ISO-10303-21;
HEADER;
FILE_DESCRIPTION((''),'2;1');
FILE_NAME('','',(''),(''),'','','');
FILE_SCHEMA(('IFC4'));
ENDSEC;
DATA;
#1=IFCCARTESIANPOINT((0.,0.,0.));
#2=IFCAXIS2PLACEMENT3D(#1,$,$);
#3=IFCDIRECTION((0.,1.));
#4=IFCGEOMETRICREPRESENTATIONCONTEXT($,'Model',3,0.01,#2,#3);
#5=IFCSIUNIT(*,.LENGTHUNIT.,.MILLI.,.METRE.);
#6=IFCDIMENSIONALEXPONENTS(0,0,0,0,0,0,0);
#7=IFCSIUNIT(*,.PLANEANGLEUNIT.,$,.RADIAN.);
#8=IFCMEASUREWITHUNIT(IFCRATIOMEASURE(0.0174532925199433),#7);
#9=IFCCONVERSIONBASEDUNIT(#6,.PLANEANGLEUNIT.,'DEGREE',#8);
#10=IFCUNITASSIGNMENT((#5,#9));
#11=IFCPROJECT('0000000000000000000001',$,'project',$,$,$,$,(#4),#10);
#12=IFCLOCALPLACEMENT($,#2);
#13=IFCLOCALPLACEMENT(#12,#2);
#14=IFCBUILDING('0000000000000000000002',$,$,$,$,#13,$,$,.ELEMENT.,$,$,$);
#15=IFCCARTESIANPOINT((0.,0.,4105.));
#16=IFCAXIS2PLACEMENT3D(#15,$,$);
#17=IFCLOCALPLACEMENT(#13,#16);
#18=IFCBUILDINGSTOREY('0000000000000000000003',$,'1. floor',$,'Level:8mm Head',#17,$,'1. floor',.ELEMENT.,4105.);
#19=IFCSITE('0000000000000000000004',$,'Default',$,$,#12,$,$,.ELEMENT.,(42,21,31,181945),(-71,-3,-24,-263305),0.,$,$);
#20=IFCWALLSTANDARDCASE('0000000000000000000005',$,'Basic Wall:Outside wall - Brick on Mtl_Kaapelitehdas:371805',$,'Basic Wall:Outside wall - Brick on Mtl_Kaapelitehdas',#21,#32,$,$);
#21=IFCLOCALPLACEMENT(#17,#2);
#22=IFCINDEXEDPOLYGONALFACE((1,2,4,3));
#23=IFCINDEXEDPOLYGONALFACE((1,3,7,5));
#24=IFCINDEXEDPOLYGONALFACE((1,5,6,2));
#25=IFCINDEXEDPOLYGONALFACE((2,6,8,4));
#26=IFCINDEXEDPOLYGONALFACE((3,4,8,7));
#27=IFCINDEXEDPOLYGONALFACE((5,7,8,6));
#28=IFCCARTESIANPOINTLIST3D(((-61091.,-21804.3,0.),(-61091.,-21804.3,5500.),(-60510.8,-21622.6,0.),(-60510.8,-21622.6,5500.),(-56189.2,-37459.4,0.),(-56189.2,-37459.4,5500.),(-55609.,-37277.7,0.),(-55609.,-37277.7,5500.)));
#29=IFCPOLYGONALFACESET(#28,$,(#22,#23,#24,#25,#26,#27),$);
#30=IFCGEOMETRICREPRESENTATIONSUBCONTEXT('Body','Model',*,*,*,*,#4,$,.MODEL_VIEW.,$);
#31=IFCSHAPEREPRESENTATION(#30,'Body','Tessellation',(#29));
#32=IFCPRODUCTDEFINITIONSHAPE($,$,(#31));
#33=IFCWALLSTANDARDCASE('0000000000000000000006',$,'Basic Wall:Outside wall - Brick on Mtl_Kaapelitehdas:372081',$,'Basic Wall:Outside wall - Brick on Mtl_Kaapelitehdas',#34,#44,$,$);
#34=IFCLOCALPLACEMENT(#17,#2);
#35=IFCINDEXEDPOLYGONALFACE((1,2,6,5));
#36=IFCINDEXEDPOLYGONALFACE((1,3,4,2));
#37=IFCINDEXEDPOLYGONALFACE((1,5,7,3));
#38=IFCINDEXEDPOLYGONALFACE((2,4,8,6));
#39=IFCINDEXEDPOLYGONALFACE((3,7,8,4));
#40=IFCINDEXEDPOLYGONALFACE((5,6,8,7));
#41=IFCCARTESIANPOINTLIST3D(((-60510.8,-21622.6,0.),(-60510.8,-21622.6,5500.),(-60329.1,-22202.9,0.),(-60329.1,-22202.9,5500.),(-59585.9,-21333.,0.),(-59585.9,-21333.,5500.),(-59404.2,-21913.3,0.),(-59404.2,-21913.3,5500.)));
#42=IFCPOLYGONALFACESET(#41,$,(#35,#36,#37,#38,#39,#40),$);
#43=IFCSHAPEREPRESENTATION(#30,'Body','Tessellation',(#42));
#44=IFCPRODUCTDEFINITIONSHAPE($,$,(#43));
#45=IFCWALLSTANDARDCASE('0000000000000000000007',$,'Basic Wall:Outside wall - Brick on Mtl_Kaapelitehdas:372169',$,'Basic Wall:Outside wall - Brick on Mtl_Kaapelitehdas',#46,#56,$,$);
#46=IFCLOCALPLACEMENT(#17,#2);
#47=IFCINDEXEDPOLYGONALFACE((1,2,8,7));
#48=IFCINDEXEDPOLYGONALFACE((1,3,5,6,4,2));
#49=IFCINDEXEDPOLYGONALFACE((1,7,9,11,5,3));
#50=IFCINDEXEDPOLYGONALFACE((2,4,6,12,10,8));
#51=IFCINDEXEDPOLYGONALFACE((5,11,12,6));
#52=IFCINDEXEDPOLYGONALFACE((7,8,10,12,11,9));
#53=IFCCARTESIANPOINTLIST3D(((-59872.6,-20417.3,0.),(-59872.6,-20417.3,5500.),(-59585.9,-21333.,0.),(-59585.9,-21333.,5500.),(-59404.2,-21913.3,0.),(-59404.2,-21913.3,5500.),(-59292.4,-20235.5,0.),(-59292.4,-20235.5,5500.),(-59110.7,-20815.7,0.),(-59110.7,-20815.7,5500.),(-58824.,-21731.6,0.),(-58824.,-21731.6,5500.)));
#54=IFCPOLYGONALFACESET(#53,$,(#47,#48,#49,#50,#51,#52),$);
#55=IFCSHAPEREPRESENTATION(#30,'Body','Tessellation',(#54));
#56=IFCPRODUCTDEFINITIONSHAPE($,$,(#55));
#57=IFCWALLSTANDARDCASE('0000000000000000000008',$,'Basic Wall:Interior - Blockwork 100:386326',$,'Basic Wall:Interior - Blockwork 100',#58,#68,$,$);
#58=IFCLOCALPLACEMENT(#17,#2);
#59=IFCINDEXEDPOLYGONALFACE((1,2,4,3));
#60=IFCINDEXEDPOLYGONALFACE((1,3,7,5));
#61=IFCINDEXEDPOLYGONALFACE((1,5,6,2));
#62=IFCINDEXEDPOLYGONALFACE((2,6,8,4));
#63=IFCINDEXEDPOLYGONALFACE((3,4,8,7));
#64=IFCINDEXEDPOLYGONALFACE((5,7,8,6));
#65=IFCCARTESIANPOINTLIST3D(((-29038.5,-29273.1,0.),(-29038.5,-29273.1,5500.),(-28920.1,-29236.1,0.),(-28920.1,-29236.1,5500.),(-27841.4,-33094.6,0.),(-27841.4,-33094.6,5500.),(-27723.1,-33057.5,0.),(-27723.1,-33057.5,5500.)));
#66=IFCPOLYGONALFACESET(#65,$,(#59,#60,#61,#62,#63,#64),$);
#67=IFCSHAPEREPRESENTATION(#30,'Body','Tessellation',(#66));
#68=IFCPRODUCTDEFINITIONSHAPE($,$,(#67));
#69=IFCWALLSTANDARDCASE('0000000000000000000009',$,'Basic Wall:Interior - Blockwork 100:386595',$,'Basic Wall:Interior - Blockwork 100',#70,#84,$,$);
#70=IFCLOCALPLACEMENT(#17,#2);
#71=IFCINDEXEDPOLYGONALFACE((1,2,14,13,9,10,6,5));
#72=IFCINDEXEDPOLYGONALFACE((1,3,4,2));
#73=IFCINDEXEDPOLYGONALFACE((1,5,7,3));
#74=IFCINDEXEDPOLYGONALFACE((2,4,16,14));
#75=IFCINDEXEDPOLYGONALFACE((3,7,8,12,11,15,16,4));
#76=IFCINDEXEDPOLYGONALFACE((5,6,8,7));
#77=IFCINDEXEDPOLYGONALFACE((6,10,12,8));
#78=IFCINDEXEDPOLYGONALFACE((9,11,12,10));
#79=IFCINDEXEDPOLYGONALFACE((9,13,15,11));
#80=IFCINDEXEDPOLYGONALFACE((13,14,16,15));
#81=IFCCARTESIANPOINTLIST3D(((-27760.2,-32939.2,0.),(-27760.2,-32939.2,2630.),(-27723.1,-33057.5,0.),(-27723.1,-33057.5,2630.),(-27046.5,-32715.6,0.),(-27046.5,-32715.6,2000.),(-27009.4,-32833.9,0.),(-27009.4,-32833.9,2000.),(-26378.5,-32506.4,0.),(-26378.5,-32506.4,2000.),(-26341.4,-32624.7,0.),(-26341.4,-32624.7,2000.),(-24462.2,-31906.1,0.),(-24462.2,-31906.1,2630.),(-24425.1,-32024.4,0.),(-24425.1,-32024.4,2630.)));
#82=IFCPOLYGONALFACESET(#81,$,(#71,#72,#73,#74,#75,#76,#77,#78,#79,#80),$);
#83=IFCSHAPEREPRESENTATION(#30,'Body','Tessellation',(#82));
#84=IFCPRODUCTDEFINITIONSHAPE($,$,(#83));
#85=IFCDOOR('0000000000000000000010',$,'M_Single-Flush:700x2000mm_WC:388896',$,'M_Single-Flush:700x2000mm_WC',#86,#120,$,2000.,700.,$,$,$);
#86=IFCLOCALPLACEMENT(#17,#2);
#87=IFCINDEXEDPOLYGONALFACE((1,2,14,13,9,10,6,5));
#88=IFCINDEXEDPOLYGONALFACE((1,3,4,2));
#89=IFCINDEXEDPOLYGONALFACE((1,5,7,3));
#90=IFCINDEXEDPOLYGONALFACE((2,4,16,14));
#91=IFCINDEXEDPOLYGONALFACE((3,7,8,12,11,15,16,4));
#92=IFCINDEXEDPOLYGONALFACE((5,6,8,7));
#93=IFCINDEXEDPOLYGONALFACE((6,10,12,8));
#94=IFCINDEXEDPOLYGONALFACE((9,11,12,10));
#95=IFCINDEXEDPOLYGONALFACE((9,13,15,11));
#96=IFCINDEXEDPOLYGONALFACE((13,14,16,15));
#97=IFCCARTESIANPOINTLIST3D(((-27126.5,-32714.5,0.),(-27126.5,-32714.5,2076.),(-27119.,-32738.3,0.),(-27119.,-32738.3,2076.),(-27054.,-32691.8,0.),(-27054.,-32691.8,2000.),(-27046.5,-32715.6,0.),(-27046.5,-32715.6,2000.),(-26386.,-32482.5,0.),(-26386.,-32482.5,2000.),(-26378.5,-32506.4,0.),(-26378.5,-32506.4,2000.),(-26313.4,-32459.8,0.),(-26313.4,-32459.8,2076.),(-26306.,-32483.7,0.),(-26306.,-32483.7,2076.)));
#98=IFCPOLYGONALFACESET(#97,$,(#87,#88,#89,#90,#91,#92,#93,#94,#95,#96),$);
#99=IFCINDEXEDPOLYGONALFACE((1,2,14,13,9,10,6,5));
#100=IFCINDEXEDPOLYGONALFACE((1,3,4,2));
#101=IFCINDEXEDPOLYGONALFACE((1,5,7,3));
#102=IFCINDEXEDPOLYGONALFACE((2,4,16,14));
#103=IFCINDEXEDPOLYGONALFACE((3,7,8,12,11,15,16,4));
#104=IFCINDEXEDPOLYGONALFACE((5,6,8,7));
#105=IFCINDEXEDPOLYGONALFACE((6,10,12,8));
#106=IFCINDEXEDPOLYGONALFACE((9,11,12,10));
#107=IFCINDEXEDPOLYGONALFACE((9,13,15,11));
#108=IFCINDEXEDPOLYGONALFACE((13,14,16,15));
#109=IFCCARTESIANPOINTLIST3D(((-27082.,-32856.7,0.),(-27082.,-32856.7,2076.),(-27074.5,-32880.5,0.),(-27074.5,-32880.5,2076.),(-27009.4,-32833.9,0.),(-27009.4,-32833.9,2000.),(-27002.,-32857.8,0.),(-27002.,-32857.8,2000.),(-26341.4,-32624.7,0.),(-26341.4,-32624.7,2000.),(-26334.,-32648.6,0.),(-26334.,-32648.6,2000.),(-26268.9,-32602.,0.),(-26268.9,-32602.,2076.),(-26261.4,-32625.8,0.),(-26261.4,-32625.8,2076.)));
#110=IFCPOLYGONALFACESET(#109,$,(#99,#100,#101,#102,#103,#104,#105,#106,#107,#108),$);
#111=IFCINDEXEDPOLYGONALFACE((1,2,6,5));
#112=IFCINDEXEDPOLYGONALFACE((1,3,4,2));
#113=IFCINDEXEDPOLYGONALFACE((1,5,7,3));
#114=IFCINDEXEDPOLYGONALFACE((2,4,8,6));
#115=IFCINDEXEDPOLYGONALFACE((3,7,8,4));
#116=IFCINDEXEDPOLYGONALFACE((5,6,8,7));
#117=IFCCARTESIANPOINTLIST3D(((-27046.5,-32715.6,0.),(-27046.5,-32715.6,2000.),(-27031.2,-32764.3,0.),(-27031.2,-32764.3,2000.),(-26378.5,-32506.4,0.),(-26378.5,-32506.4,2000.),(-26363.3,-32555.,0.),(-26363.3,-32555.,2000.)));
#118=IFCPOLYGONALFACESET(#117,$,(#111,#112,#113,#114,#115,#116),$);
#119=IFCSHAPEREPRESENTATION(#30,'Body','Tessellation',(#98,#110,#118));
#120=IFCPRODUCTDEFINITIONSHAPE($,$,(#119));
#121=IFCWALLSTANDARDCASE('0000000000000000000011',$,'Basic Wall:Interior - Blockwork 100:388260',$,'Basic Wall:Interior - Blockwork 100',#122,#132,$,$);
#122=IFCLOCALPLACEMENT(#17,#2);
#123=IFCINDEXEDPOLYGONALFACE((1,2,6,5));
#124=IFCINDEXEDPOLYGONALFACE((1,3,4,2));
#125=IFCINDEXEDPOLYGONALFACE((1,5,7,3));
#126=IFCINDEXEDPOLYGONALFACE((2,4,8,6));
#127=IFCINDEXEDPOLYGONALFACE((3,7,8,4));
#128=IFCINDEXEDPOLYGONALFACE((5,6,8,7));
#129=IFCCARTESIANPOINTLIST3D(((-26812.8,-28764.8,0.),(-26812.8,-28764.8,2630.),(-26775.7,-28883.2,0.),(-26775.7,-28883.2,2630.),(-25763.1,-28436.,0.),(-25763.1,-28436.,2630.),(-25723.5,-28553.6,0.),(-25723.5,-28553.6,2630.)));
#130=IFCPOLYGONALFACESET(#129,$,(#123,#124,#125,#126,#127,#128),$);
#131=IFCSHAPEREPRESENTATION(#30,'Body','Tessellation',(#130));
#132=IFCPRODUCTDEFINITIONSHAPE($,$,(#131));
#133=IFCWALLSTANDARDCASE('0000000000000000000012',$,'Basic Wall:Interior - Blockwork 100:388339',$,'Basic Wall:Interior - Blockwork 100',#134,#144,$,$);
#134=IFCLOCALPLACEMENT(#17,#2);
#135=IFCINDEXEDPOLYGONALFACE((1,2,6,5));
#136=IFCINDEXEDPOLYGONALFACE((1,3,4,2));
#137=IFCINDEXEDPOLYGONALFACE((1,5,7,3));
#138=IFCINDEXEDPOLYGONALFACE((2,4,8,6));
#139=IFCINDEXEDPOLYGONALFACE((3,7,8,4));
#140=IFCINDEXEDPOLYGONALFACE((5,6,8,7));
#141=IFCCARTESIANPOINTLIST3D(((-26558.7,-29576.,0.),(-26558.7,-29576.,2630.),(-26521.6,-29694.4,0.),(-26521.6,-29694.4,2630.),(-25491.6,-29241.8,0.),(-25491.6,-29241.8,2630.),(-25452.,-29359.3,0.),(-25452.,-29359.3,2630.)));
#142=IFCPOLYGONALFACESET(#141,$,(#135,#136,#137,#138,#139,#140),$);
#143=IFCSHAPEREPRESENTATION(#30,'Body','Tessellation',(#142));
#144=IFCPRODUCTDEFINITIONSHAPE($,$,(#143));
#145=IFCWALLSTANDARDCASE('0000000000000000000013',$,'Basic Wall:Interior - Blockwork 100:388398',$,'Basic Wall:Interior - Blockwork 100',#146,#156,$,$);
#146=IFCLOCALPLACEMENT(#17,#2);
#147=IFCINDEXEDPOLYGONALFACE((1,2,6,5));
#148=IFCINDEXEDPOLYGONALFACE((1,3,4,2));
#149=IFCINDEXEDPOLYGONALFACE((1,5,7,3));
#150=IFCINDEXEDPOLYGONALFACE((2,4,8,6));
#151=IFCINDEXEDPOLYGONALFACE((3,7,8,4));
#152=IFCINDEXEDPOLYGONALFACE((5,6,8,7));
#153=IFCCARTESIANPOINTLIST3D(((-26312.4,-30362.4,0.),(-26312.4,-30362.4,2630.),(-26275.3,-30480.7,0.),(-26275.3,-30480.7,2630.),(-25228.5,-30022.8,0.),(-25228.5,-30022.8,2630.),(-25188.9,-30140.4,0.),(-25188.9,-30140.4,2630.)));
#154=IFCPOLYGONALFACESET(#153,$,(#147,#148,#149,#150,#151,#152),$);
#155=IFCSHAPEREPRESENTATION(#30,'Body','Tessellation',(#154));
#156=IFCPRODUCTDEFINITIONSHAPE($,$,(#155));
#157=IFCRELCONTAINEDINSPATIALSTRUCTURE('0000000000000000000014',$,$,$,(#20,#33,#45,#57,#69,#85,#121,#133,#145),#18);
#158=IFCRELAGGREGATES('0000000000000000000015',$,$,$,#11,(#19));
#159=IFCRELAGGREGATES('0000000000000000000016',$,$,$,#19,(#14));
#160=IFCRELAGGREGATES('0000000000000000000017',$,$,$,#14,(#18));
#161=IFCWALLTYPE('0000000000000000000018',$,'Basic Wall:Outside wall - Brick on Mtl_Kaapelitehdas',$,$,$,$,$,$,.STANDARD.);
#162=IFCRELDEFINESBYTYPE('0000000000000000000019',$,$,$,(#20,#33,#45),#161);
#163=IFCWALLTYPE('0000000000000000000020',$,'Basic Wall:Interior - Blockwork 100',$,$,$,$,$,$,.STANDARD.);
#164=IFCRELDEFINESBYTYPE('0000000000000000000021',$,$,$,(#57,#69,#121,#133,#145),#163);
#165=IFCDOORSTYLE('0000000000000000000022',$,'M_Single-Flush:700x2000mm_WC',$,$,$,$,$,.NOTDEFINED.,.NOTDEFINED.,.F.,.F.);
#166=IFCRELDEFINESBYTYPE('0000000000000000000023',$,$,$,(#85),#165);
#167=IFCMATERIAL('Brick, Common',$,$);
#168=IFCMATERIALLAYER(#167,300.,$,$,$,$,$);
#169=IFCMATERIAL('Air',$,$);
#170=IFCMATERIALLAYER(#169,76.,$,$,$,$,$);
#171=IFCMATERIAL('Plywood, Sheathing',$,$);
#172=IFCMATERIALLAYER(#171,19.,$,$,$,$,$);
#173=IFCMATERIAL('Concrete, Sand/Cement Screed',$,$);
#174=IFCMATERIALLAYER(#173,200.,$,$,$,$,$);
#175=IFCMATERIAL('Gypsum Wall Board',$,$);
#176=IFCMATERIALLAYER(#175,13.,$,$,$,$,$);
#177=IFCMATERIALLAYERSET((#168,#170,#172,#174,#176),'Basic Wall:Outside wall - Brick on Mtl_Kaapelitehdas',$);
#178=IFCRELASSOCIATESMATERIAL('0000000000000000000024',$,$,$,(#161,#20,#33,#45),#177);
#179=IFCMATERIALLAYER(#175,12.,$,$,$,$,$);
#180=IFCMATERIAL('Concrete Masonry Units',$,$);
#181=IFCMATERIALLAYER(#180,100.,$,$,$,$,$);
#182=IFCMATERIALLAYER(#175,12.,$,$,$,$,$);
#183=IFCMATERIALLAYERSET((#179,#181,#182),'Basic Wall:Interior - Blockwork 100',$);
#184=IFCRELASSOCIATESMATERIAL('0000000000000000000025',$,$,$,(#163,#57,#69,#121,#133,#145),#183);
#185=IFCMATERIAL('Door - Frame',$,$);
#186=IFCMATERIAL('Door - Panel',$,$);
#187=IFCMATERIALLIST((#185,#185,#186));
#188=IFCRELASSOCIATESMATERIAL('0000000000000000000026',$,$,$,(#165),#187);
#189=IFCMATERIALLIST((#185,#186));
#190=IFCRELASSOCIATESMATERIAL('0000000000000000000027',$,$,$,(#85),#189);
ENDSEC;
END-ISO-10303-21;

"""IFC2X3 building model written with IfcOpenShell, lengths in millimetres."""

from ifc_helpers import new_model, entity, si_unit, converted_unit, direction, frame, frame_2d, origin, origin_2d_with_axis, place, context, subcontext, project, spatial, polyline, rectangle, outline, extrude, source, transform, mapped, material, material_list, layer, layer_set, layer_usage, type_object, type_shapes, element, fill, save


model = new_model("IFC2X3")

# Units and contexts
model_context = context("Model", 3, precision=0.01, world=origin(), true_north=direction((0.0, 1.0)))
body_context = subcontext(model_context, "Body", "Model", "MODEL_VIEW")
ifc_project = project(units=[si_unit("LENGTHUNIT", "METRE", prefix="MILLI"), converted_unit("PLANEANGLEUNIT", "DEGREE", entity("IfcRatioMeasure", 0.0174532925199433), si_unit("PLANEANGLEUNIT", "RADIAN"), dimensions=[0, 0, 0, 0, 0, 0, 0])], contexts=[model_context])

# Site, building, storey
site_placement = place(None, origin())
site = spatial("IfcSite", under=ifc_project, at=site_placement, Name="Default", CompositionType="ELEMENT", RefLatitude=(42, 21, 31, 181945), RefLongitude=(-71, -3, -24, -263305), RefElevation=0.0)
building_placement = place(site_placement, origin())
building = spatial("IfcBuilding", under=site, at=building_placement, CompositionType="ELEMENT")
storey_placement = place(building_placement, frame((0.0, 0.0, 4105.0)))
storey = spatial("IfcBuildingStorey", under=building, at=storey_placement, Name="1. floor", ObjectType="Level:8mm Head", LongName="1. floor", CompositionType="ELEMENT", Elevation=4105.0)

# Walls
ifc_material_1 = material(Name="Brick, Common")
ifc_layer_1 = layer(ifc_material_1, 300.0)
ifc_material_2 = material(Name="Air")
ifc_layer_2 = layer(ifc_material_2, 76.0)
ifc_material_3 = material(Name="Plywood, Sheathing")
ifc_layer_3 = layer(ifc_material_3, 19.0)
ifc_material_4 = material(Name="Concrete, Sand/Cement Screed")
ifc_layer_4 = layer(ifc_material_4, 200.0)
ifc_material_5 = material(Name="Gypsum Wall Board")
ifc_layer_5 = layer(ifc_material_5, 13.0)
ifc_layer_set_1 = layer_set([ifc_layer_1, ifc_layer_2, ifc_layer_3, ifc_layer_4, ifc_layer_5], Name="Basic Wall:Outside wall - Brick on Mtl_Kaapelitehdas")
ifc_layer_usage_1 = layer_usage(ifc_layer_set_1, "AXIS2", "NEGATIVE", 304.0)
wall_type_1 = type_object("IfcWallType", Name="Basic Wall:Outside wall - Brick on Mtl_Kaapelitehdas", PredefinedType="STANDARD", material=ifc_layer_set_1)
wall_1_placement = place(storey_placement, frame((-60800.9, -21713.5, 0.0), z_axis=(0.0, 0.0, 1.0), x_axis=(0.298805, -0.954314, 0.0)))
element("IfcWallStandardCase", 1, at=wall_1_placement, inside=storey, type_object=wall_type_1, material=ifc_layer_usage_1, Name="Basic Wall:Outside wall - Brick on Mtl_Kaapelitehdas:371805", ObjectType="Basic Wall:Outside wall - Brick on Mtl_Kaapelitehdas", context=body_context, shape_type="SweptSolid", body=[
    extrude(rectangle(XDim=16404.5, YDim=608.0, at=frame_2d((8202.3, 0.0), x_axis=(-1.0, 0.0))), origin(), (0.0, 0.0, 1.0), 5500.0),
])
ifc_layer_usage_2 = layer_usage(ifc_layer_set_1, "AXIS2", "NEGATIVE", 304.0)
wall_2_placement = place(storey_placement, frame((-60419.9, -21912.8, 0.0), z_axis=(0.0, 0.0, 1.0), x_axis=(0.954314, 0.298805, 0.0)))
element("IfcWallStandardCase", 2, at=wall_2_placement, inside=storey, type_object=wall_type_1, material=ifc_layer_usage_2, Name="Basic Wall:Outside wall - Brick on Mtl_Kaapelitehdas:372081", ObjectType="Basic Wall:Outside wall - Brick on Mtl_Kaapelitehdas", context=body_context, shape_type="SweptSolid", body=[
    extrude(rectangle(XDim=969.2, YDim=608.0, at=frame_2d((484.6, 0.0), x_axis=(-1.0, 0.0))), origin(), (0.0, 0.0, 1.0), 5500.0),
])
ifc_layer_usage_3 = layer_usage(ifc_layer_set_1, "AXIS2", "NEGATIVE", 304.0)
wall_3_placement = place(storey_placement, frame((-59114.1, -21822.4, 0.0), z_axis=(0.0, 0.0, 1.0), x_axis=(-0.298805, 0.954314, 0.0)))
element("IfcWallStandardCase", 3, at=wall_3_placement, inside=storey, type_object=wall_type_1, material=ifc_layer_usage_3, Name="Basic Wall:Outside wall - Brick on Mtl_Kaapelitehdas:372169", ObjectType="Basic Wall:Outside wall - Brick on Mtl_Kaapelitehdas", context=body_context, shape_type="SweptSolid", body=[
    extrude(outline(polyline([(1567.7, -304.0), (1567.6, 304.0), (608.0, 304.0), (0.0, 304.0), (0.0, -304.0), (959.7, -304.0), (1567.7, -304.0)])), origin(), (0.0, 0.0, 1.0), 5500.0),
])

# Wall
ifc_layer_6 = layer(ifc_material_5, 12.0)
ifc_material_6 = material(Name="Concrete Masonry Units")
ifc_layer_7 = layer(ifc_material_6, 100.0)
ifc_layer_8 = layer(ifc_material_5, 12.0)
ifc_layer_set_2 = layer_set([ifc_layer_6, ifc_layer_7, ifc_layer_8], Name="Basic Wall:Interior - Blockwork 100")
ifc_layer_usage_4 = layer_usage(ifc_layer_set_2, "AXIS2", "NEGATIVE", 62.0)
wall_type_2 = type_object("IfcWallType", Name="Basic Wall:Interior - Blockwork 100", PredefinedType="STANDARD", material=ifc_layer_set_2)
wall_4_placement = place(storey_placement, frame((-28979.3, -29254.6, 0.0), z_axis=(0.0, 0.0, 1.0), x_axis=(0.298924, -0.954277, 0.0)))
element("IfcWallStandardCase", 4, at=wall_4_placement, inside=storey, type_object=wall_type_2, material=ifc_layer_usage_4, Name="Basic Wall:Interior - Blockwork 100:386326", ObjectType="Basic Wall:Interior - Blockwork 100", context=body_context, shape_type="SweptSolid", body=[
    extrude(rectangle(XDim=4004.5, YDim=124.0, at=frame_2d((2002.3, 0.0), x_axis=(-1.0, 0.0))), origin(), (0.0, 0.0, 1.0), 5500.0),
])

# Wall, opening, door
ifc_layer_usage_5 = layer_usage(ifc_layer_set_2, "AXIS2", "NEGATIVE", 62.0)
wall_5_placement = place(storey_placement, frame((-27741.6, -32998.3, 0.0), z_axis=(0.0, 0.0, 1.0), x_axis=(0.954277, 0.298924, 0.0)))
wall_5 = element("IfcWallStandardCase", 5, at=wall_5_placement, inside=storey, type_object=wall_type_2, material=ifc_layer_usage_5, Name="Basic Wall:Interior - Blockwork 100:386595", ObjectType="Basic Wall:Interior - Blockwork 100", context=body_context, shape_type="SweptSolid", body=[
    extrude(rectangle(XDim=3456.0, YDim=124.0, at=frame_2d((1728.0, 0.0), x_axis=(-1.0, 0.0))), origin(), (0.0, 0.0, 1.0), 2630.0),
])
opening_1_placement = place(wall_5_placement, frame((747.9, -62.0, 0.0)))
opening_1 = element("IfcOpeningElement", 6, at=opening_1_placement, cuts=wall_5, ObjectType="Opening", context=body_context, shape_type="SweptSolid", body=[
    extrude(rectangle(XDim=700.0, YDim=2000.0, at=frame_2d((1000.0, 350.0), x_axis=(0.0, 1.0))), frame((0.0, 0.0, 0.0), z_axis=(0.0, 1.0, 0.0), x_axis=(0.0, 0.0, 1.0)), (0.0, 0.0, 1.0), 124.0),
])
ifc_material_7 = material(Name="Door - Frame")
ifc_material_8 = material(Name="Door - Panel")
ifc_material_list_1 = material_list([ifc_material_7, ifc_material_8])
ifc_material_list_2 = material_list([ifc_material_7, ifc_material_7, ifc_material_8])
door_style_1 = type_object("IfcDoorStyle", Name="M_Single-Flush:700x2000mm_WC", ConstructionType="NOTDEFINED", OperationType="NOTDEFINED", ParameterTakesPrecedence=False, Sizeable=False, material=ifc_material_list_2)
shared_shape_1 = source(origin(), body_context, "Body", "SweptSolid", [
    extrude(outline(polyline([(-426.0, -1057.0), (426.0, -1057.0), (426.0, 1019.0), (350.0, 1019.0), (350.0, -981.0), (-350.0, -981.0), (-350.0, 1019.0), (-426.0, 1019.0), (-426.0, -1057.0)])), frame((350.0, 124.0, 1019.0), z_axis=(0.0, 1.0, 0.0), x_axis=(1.0, 0.0, 0.0)), (0.0, 0.0, 1.0), 25.0),
    extrude(outline(polyline([(-1057.0, -426.0), (1019.0, -426.0), (1019.0, -350.0), (-981.0, -350.0), (-981.0, 350.0), (1019.0, 350.0), (1019.0, 426.0), (-1057.0, 426.0), (-1057.0, -426.0)])), frame((350.0, -25.0, 1019.0), z_axis=(0.0, 1.0, 0.0), x_axis=(0.0, 0.0, -1.0)), (0.0, 0.0, 1.0), 25.0),
    extrude(rectangle(XDim=51.0, YDim=700.0, at=origin_2d_with_axis()), frame((350.0, 98.5, 0.0), z_axis=(0.0, 0.0, 1.0), x_axis=(0.0, 1.0, 0.0)), (0.0, 0.0, 1.0), 2000.0),
])
type_shapes(door_style_1, [shared_shape_1])
door_1_placement = place(opening_1_placement, origin())
door_1 = element("IfcDoor", 7, at=door_1_placement, inside=storey, type_object=door_style_1, material=ifc_material_list_1, Name="M_Single-Flush:700x2000mm_WC:388896", ObjectType="M_Single-Flush:700x2000mm_WC", OverallHeight=2000.0, OverallWidth=700.0, context=body_context, shape_type="MappedRepresentation", body=[
    mapped(shared_shape_1, transform((0.0, 0.0, 0.0), scale=1.0)),
])
fill(opening_1, door_1)

# Walls
ifc_layer_usage_6 = layer_usage(ifc_layer_set_2, "AXIS2", "NEGATIVE", 62.0)
wall_6_placement = place(storey_placement, frame((-26794.3, -28824.0, 0.0), z_axis=(0.0, 0.0, 1.0), x_axis=(0.954277, 0.298924, 0.0)))
element("IfcWallStandardCase", 8, at=wall_6_placement, inside=storey, type_object=wall_type_2, material=ifc_layer_usage_6, Name="Basic Wall:Interior - Blockwork 100:388260", ObjectType="Basic Wall:Interior - Blockwork 100", context=body_context, shape_type="SweptSolid", body=[
    extrude(outline(polyline([(1102.6, -62.0), (1100.0, 62.0), (0.0, 62.0), (0.0, -62.0), (1102.6, -62.0)])), origin(), (0.0, 0.0, 1.0), 2630.0),
])
ifc_layer_usage_7 = layer_usage(ifc_layer_set_2, "AXIS2", "NEGATIVE", 62.0)
wall_7_placement = place(storey_placement, frame((-26540.1, -29635.2, 0.0), z_axis=(0.0, 0.0, 1.0), x_axis=(0.954277, 0.298924, 0.0)))
element("IfcWallStandardCase", 9, at=wall_7_placement, inside=storey, type_object=wall_type_2, material=ifc_layer_usage_7, Name="Basic Wall:Interior - Blockwork 100:388339", ObjectType="Basic Wall:Interior - Blockwork 100", context=body_context, shape_type="SweptSolid", body=[
    extrude(outline(polyline([(1120.8, -62.0), (1118.2, 62.0), (0.0, 62.0), (0.0, -62.0), (1120.8, -62.0)])), origin(), (0.0, 0.0, 1.0), 2630.0),
])
ifc_layer_usage_8 = layer_usage(ifc_layer_set_2, "AXIS2", "NEGATIVE", 62.0)
wall_8_placement = place(storey_placement, frame((-26293.8, -30421.5, 0.0), z_axis=(0.0, 0.0, 1.0), x_axis=(0.954277, 0.298924, 0.0)))
element("IfcWallStandardCase", 10, at=wall_8_placement, inside=storey, type_object=wall_type_2, material=ifc_layer_usage_8, Name="Basic Wall:Interior - Blockwork 100:388398", ObjectType="Basic Wall:Interior - Blockwork 100", context=body_context, shape_type="SweptSolid", body=[
    extrude(outline(polyline([(1138.5, -62.0), (1135.8, 62.0), (0.0, 62.0), (0.0, -62.0), (1138.5, -62.0)])), origin(), (0.0, 0.0, 1.0), 2630.0),
])

save(model, "model.ifc")
